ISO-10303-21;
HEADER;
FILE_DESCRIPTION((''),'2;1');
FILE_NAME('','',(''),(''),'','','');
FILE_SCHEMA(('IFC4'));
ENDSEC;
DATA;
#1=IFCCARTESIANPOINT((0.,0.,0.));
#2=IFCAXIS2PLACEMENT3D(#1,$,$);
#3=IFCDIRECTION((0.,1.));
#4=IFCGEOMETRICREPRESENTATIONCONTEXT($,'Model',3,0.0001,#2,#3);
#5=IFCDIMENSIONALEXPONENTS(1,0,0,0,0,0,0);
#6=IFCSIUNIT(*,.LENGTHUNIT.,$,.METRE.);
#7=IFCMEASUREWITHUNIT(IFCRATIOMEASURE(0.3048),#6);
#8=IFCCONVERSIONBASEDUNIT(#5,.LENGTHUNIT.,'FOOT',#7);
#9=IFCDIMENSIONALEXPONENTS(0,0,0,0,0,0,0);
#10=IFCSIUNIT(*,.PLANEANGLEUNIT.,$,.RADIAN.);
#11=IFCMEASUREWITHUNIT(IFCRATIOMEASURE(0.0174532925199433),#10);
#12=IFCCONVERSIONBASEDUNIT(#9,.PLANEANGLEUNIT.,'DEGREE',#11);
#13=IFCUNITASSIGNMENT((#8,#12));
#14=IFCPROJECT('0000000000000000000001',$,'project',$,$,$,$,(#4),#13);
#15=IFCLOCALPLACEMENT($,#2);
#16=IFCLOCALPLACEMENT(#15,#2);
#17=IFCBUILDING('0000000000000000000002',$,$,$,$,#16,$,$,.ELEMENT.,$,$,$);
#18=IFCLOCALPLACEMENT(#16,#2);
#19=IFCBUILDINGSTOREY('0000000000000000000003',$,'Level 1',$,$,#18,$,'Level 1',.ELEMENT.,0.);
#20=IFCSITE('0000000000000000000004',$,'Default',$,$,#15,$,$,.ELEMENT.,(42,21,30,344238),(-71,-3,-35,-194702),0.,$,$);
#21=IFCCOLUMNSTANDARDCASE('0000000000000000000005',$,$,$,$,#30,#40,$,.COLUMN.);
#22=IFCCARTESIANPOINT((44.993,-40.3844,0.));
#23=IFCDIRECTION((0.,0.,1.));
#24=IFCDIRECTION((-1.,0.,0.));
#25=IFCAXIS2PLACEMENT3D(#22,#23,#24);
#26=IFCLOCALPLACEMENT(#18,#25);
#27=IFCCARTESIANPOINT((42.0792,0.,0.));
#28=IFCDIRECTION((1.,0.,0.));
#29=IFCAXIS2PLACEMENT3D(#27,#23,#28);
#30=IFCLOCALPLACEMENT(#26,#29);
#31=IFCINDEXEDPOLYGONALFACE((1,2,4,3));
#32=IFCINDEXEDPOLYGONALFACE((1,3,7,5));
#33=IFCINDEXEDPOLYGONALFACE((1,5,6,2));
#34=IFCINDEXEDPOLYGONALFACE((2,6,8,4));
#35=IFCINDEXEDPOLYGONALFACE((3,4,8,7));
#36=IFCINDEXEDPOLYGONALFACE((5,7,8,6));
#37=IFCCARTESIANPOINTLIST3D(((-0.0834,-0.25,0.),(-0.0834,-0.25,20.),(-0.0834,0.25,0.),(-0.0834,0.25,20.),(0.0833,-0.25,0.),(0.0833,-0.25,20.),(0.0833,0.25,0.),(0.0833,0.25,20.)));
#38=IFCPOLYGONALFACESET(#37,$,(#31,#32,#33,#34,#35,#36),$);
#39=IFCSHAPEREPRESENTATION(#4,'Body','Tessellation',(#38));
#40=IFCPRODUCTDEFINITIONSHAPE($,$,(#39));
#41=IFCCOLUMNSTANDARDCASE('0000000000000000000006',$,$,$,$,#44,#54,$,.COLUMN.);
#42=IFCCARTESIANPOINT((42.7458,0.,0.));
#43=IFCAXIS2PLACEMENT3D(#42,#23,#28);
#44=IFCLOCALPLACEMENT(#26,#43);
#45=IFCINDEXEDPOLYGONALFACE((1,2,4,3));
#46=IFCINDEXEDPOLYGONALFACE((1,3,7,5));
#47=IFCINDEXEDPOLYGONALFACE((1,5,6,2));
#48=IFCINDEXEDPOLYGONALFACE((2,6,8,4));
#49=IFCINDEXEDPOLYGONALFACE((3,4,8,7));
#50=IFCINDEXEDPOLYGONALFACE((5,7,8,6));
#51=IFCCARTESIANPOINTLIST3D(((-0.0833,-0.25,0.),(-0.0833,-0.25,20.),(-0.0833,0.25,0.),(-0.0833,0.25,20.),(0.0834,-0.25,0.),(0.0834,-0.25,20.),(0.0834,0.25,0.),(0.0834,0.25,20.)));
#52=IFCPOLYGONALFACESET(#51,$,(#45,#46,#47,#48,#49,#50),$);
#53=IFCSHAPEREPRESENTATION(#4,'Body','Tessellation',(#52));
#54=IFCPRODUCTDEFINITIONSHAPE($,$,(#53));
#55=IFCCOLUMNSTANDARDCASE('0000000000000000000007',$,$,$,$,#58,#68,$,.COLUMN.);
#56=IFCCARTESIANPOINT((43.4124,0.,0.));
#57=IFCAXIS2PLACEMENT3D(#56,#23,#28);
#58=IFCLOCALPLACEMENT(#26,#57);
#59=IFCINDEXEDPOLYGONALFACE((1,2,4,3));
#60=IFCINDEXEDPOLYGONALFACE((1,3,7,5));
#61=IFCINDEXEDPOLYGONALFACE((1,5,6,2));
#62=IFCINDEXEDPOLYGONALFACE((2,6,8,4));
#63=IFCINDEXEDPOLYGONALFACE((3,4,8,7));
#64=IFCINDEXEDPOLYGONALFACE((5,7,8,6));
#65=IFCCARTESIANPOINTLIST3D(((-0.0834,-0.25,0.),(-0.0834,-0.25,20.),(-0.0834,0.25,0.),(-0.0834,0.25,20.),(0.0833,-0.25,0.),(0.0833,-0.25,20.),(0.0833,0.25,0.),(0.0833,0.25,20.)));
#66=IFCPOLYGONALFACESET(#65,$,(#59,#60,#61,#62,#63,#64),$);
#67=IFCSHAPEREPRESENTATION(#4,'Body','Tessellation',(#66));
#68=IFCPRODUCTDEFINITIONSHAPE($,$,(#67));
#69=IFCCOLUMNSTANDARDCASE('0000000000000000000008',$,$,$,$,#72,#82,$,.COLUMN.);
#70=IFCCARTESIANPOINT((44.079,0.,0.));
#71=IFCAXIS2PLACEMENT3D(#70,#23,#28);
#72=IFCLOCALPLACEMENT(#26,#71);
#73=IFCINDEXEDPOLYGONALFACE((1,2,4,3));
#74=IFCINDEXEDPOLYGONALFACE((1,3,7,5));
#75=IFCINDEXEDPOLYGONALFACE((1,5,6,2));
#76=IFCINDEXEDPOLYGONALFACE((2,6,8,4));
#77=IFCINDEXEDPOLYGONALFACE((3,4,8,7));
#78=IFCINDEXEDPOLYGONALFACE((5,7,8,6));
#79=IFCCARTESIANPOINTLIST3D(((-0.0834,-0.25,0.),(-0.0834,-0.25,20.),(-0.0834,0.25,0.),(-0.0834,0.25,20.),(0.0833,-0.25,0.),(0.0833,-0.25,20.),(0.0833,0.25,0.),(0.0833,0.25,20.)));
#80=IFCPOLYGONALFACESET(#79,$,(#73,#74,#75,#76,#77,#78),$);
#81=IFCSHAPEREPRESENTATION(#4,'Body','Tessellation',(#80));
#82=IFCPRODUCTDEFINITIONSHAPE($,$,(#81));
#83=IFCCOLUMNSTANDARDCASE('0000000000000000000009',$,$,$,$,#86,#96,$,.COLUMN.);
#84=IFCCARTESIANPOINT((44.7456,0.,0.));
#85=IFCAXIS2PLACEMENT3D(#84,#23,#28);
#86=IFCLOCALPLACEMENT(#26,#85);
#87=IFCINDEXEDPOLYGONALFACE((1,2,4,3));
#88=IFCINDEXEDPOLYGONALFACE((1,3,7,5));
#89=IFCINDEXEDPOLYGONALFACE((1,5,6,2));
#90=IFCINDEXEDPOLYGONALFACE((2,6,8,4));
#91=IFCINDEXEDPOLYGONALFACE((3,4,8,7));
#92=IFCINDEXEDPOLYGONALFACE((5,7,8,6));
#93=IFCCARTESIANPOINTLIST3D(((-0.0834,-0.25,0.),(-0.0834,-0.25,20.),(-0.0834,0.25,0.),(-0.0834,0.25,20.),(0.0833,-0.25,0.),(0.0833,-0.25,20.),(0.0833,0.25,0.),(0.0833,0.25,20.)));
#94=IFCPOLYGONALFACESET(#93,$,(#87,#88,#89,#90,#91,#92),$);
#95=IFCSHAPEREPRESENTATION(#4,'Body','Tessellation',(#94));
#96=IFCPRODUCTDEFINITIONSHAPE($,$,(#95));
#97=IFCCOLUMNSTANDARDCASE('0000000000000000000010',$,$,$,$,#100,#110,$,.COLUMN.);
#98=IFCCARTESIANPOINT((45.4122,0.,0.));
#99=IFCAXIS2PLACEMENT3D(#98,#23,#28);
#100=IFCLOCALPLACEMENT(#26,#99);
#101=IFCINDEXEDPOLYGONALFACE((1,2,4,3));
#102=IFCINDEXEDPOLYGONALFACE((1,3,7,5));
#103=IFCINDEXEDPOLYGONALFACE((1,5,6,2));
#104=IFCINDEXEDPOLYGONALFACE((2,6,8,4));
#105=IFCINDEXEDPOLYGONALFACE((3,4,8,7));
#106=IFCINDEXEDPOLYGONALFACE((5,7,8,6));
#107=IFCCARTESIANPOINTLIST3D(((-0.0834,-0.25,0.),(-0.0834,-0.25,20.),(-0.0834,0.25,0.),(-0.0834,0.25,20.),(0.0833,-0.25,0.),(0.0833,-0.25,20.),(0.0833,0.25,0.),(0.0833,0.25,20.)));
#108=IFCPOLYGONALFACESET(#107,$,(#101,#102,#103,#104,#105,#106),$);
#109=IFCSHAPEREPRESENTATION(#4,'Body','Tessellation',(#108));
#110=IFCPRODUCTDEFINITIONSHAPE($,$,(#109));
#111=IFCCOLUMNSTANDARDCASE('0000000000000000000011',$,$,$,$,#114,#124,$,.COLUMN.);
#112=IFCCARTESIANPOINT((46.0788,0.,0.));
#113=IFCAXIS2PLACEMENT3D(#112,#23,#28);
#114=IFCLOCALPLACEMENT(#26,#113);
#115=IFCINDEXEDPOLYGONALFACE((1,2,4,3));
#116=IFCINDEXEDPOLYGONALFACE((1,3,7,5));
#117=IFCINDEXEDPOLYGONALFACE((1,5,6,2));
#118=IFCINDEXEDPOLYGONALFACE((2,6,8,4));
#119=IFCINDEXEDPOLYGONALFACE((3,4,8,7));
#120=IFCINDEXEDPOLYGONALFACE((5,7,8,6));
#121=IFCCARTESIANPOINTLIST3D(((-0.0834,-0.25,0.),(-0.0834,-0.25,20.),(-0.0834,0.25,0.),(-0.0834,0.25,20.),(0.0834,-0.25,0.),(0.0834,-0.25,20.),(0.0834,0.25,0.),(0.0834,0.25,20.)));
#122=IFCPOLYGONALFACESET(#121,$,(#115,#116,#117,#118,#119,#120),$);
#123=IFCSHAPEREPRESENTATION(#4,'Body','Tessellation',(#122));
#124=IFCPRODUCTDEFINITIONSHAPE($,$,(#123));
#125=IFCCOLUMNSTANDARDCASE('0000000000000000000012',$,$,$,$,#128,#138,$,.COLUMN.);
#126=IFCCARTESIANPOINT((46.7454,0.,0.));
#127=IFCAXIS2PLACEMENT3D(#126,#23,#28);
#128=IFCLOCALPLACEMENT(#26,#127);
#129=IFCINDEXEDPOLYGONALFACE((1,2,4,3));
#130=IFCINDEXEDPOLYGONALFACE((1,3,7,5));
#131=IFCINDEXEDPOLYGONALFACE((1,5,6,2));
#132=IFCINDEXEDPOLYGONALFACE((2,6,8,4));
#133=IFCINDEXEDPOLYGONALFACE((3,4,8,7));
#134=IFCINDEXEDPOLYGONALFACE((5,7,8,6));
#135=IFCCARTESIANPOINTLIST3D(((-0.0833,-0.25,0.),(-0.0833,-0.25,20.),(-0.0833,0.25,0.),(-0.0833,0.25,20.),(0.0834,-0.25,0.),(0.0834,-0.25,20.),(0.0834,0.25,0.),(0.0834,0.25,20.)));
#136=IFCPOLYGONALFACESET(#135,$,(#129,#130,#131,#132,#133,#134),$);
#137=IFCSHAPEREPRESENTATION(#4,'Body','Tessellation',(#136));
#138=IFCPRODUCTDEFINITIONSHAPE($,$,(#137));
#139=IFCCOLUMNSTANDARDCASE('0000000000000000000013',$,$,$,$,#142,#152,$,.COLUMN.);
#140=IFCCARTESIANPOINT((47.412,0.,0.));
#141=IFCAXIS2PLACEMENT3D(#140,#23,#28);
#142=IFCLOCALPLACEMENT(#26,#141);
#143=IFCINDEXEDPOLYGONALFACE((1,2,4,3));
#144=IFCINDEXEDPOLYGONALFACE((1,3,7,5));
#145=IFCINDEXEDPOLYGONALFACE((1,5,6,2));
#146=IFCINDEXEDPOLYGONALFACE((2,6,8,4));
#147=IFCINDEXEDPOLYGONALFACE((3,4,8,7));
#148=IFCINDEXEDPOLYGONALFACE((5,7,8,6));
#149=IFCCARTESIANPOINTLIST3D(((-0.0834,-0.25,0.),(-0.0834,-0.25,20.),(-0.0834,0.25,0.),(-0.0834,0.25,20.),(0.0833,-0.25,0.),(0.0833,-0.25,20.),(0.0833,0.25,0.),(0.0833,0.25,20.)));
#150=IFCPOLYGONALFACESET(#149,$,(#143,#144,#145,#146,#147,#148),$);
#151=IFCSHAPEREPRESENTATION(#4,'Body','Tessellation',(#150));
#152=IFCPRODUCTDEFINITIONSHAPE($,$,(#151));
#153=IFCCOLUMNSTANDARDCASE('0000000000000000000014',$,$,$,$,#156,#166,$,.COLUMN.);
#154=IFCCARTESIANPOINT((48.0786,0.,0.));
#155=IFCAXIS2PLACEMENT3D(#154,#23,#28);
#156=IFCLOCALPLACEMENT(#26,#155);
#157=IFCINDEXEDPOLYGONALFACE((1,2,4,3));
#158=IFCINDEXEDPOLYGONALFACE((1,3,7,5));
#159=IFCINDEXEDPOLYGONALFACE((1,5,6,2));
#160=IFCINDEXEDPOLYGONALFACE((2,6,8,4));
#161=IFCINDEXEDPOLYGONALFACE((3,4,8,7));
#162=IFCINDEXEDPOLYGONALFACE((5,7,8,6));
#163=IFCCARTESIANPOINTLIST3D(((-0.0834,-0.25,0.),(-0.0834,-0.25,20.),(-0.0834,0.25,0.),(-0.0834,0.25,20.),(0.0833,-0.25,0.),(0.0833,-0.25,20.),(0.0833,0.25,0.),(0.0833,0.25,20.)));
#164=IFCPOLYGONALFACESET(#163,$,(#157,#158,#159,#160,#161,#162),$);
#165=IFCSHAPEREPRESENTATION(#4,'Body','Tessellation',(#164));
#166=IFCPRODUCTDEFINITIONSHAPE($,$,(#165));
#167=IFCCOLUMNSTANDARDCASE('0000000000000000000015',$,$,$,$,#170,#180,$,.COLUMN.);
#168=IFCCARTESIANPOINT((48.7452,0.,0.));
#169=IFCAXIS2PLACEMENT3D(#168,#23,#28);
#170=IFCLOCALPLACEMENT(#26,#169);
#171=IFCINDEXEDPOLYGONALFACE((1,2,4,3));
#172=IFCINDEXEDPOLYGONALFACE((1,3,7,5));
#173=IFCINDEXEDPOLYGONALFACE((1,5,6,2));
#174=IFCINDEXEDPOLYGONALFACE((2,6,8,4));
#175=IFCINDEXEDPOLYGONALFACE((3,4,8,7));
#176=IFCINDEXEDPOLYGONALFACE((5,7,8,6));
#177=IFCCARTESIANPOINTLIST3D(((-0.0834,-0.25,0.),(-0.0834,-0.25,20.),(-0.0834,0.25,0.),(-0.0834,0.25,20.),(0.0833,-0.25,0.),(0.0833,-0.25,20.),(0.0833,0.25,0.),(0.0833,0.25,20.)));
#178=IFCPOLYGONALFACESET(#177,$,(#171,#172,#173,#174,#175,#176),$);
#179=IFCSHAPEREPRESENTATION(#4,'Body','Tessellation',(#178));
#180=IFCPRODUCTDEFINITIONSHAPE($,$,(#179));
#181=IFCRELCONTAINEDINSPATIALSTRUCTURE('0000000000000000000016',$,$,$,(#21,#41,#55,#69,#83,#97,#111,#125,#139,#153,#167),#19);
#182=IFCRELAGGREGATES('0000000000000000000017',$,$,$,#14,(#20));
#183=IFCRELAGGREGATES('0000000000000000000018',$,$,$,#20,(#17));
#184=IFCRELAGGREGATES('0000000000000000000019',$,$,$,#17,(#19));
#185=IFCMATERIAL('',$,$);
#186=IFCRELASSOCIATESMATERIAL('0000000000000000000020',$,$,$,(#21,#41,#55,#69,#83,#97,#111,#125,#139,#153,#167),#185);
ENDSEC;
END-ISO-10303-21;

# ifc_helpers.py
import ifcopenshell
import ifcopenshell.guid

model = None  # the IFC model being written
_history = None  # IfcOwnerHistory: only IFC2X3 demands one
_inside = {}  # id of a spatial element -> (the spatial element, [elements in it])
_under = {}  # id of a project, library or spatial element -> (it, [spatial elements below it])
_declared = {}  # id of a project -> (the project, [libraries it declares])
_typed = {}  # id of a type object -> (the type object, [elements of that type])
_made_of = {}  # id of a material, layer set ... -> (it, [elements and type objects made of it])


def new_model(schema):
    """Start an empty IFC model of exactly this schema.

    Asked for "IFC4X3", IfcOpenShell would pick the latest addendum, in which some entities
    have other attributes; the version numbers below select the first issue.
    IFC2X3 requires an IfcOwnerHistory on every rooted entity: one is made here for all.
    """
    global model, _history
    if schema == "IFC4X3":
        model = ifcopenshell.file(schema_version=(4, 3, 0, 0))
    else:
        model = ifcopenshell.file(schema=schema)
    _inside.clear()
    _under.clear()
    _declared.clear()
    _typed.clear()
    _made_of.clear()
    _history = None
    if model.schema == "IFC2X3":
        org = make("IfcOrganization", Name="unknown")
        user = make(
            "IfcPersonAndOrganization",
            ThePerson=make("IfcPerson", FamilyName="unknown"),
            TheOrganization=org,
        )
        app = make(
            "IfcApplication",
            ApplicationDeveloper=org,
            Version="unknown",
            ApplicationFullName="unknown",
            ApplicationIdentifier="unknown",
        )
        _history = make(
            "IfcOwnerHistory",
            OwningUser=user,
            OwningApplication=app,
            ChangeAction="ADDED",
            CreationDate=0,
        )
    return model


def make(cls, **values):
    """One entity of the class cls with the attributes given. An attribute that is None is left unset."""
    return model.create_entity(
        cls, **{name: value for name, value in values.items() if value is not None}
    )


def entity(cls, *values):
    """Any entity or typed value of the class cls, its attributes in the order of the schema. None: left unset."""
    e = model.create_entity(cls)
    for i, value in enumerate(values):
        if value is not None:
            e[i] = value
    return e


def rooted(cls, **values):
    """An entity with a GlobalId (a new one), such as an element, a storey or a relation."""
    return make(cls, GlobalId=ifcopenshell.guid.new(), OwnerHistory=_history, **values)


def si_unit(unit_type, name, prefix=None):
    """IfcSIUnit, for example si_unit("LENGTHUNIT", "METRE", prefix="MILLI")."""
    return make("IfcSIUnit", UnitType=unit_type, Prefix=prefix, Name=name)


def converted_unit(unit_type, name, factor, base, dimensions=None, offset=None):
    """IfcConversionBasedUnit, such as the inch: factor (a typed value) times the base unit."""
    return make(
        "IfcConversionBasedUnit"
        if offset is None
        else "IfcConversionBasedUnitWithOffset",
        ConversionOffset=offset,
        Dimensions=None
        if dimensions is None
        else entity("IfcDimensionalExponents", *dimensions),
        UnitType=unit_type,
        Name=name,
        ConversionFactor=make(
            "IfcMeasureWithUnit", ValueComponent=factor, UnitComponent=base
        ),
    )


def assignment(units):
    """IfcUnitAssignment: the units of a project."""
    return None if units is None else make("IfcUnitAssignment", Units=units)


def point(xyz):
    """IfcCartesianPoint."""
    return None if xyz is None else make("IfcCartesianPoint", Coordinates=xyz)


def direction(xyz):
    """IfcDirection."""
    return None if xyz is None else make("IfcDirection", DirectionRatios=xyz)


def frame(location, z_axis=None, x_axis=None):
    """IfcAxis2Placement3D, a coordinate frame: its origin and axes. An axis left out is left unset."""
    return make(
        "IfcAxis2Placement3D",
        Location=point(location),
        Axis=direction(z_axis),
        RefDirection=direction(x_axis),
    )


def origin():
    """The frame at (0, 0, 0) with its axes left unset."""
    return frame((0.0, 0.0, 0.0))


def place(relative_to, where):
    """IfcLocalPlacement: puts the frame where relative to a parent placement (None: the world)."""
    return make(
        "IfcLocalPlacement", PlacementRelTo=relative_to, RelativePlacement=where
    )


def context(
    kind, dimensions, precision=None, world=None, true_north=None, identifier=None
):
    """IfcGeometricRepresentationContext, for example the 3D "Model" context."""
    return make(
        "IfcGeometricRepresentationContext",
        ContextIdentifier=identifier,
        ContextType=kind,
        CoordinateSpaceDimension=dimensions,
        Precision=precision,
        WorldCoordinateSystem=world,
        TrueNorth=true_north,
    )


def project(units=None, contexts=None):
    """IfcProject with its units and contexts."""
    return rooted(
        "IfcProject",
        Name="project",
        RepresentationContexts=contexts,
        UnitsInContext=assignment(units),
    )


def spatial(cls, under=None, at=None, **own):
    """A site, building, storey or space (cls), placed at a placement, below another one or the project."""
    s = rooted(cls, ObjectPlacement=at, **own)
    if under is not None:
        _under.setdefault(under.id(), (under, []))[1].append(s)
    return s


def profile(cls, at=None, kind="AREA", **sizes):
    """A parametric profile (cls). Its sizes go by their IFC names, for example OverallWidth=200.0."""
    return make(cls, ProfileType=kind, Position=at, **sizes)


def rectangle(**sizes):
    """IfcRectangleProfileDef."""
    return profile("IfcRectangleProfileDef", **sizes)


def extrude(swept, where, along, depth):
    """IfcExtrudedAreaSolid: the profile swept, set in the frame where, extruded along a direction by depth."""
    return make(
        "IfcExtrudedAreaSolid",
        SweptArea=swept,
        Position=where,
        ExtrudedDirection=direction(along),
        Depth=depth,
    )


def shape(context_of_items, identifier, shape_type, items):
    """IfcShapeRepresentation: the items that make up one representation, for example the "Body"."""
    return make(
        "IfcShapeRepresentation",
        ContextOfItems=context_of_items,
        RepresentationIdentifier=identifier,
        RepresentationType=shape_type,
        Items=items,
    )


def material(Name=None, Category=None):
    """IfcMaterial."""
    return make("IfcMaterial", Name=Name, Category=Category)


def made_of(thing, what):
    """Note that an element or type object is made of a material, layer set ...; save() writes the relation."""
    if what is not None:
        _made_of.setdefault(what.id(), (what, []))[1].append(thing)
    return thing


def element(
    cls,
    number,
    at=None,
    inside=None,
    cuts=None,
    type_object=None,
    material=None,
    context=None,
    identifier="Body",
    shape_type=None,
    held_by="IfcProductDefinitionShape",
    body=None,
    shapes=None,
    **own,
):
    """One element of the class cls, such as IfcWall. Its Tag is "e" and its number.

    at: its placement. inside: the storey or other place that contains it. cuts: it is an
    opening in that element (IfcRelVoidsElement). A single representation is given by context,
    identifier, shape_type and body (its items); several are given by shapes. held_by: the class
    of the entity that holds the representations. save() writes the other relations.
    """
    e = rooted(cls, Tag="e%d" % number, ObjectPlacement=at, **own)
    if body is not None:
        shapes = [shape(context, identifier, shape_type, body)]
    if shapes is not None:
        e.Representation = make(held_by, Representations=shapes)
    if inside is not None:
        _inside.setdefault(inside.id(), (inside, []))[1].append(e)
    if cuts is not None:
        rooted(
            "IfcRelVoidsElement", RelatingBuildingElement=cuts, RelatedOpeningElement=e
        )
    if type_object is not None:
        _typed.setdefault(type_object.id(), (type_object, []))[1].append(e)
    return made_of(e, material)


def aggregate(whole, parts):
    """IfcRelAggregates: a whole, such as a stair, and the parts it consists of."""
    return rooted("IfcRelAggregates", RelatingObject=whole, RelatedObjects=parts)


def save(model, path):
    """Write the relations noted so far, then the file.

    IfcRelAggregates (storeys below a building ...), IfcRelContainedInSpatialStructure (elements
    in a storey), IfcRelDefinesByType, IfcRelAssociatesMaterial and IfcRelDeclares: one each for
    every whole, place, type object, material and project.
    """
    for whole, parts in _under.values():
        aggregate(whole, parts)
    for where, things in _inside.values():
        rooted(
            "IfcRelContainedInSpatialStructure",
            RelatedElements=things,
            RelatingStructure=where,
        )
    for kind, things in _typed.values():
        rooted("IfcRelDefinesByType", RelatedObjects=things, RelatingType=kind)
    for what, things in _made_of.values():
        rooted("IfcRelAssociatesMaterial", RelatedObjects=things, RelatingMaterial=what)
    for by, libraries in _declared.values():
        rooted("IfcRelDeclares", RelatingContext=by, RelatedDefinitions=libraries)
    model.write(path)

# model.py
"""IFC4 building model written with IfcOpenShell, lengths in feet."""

from ifc_helpers import new_model, entity, si_unit, converted_unit, direction, frame, origin, place, context, project, spatial, rectangle, extrude, material, element, save


model = new_model("IFC4")

# Units and contexts
model_context = context("Model", 3, precision=0.0001, world=origin(), true_north=direction((0.0, 1.0)))
ifc_project = project(units=[converted_unit("LENGTHUNIT", "FOOT", entity("IfcRatioMeasure", 0.3048), si_unit("LENGTHUNIT", "METRE"), dimensions=[1, 0, 0, 0, 0, 0, 0]), converted_unit("PLANEANGLEUNIT", "DEGREE", entity("IfcRatioMeasure", 0.0174532925199433), si_unit("PLANEANGLEUNIT", "RADIAN"), dimensions=[0, 0, 0, 0, 0, 0, 0])], contexts=[model_context])

# Site, building, storey
site_placement = place(None, origin())
site = spatial("IfcSite", under=ifc_project, at=site_placement, Name="Default", CompositionType="ELEMENT", RefLatitude=(42, 21, 30, 344238), RefLongitude=(-71, -3, -35, -194702), RefElevation=0.0)
building_placement = place(site_placement, origin())
building = spatial("IfcBuilding", under=site, at=building_placement, CompositionType="ELEMENT")
storey_placement = place(building_placement, origin())
storey = spatial("IfcBuildingStorey", under=building, at=storey_placement, Name="Level 1", LongName="Level 1", CompositionType="ELEMENT", Elevation=0.0)

# Columns
ifc_material_1 = material(Name="")
placement = place(storey_placement, frame((44.993, -40.3844, 0.0), z_axis=(0.0, 0.0, 1.0), x_axis=(-1.0, 0.0, 0.0)))
for number, where, z_axis, x_axis in (
    (1, (42.0792, 0.0, 0.0), (0.0, 0.0, 1.0), (1.0, 0.0, 0.0)),
    (2, (42.7458, 0.0, 0.0), (0.0, 0.0, 1.0), (1.0, 0.0, 0.0)),
    (3, (43.4124, 0.0, 0.0), (0.0, 0.0, 1.0), (1.0, 0.0, 0.0)),
    (4, (44.079, 0.0, 0.0), (0.0, 0.0, 1.0), (1.0, 0.0, 0.0)),
    (5, (44.7456, 0.0, 0.0), (0.0, 0.0, 1.0), (1.0, 0.0, 0.0)),
    (6, (45.4122, 0.0, 0.0), (0.0, 0.0, 1.0), (1.0, 0.0, 0.0)),
    (7, (46.0788, 0.0, 0.0), (0.0, 0.0, 1.0), (1.0, 0.0, 0.0)),
    (8, (46.7454, 0.0, 0.0), (0.0, 0.0, 1.0), (1.0, 0.0, 0.0)),
    (9, (47.412, 0.0, 0.0), (0.0, 0.0, 1.0), (1.0, 0.0, 0.0)),
    (10, (48.0786, 0.0, 0.0), (0.0, 0.0, 1.0), (1.0, 0.0, 0.0)),
    (11, (48.7452, 0.0, 0.0), (0.0, 0.0, 1.0), (1.0, 0.0, 0.0)),
):
    element("IfcColumnStandardCase", number, at=place(placement, frame(where, z_axis=z_axis, x_axis=x_axis)), inside=storey, material=ifc_material_1, PredefinedType="COLUMN", context=model_context, shape_type="SweptSolid", body=[
        extrude(rectangle(XDim=0.1667, YDim=0.5), origin(), (0.0, 0.0, 1.0), 20.0),
    ])

save(model, "model.ifc")
